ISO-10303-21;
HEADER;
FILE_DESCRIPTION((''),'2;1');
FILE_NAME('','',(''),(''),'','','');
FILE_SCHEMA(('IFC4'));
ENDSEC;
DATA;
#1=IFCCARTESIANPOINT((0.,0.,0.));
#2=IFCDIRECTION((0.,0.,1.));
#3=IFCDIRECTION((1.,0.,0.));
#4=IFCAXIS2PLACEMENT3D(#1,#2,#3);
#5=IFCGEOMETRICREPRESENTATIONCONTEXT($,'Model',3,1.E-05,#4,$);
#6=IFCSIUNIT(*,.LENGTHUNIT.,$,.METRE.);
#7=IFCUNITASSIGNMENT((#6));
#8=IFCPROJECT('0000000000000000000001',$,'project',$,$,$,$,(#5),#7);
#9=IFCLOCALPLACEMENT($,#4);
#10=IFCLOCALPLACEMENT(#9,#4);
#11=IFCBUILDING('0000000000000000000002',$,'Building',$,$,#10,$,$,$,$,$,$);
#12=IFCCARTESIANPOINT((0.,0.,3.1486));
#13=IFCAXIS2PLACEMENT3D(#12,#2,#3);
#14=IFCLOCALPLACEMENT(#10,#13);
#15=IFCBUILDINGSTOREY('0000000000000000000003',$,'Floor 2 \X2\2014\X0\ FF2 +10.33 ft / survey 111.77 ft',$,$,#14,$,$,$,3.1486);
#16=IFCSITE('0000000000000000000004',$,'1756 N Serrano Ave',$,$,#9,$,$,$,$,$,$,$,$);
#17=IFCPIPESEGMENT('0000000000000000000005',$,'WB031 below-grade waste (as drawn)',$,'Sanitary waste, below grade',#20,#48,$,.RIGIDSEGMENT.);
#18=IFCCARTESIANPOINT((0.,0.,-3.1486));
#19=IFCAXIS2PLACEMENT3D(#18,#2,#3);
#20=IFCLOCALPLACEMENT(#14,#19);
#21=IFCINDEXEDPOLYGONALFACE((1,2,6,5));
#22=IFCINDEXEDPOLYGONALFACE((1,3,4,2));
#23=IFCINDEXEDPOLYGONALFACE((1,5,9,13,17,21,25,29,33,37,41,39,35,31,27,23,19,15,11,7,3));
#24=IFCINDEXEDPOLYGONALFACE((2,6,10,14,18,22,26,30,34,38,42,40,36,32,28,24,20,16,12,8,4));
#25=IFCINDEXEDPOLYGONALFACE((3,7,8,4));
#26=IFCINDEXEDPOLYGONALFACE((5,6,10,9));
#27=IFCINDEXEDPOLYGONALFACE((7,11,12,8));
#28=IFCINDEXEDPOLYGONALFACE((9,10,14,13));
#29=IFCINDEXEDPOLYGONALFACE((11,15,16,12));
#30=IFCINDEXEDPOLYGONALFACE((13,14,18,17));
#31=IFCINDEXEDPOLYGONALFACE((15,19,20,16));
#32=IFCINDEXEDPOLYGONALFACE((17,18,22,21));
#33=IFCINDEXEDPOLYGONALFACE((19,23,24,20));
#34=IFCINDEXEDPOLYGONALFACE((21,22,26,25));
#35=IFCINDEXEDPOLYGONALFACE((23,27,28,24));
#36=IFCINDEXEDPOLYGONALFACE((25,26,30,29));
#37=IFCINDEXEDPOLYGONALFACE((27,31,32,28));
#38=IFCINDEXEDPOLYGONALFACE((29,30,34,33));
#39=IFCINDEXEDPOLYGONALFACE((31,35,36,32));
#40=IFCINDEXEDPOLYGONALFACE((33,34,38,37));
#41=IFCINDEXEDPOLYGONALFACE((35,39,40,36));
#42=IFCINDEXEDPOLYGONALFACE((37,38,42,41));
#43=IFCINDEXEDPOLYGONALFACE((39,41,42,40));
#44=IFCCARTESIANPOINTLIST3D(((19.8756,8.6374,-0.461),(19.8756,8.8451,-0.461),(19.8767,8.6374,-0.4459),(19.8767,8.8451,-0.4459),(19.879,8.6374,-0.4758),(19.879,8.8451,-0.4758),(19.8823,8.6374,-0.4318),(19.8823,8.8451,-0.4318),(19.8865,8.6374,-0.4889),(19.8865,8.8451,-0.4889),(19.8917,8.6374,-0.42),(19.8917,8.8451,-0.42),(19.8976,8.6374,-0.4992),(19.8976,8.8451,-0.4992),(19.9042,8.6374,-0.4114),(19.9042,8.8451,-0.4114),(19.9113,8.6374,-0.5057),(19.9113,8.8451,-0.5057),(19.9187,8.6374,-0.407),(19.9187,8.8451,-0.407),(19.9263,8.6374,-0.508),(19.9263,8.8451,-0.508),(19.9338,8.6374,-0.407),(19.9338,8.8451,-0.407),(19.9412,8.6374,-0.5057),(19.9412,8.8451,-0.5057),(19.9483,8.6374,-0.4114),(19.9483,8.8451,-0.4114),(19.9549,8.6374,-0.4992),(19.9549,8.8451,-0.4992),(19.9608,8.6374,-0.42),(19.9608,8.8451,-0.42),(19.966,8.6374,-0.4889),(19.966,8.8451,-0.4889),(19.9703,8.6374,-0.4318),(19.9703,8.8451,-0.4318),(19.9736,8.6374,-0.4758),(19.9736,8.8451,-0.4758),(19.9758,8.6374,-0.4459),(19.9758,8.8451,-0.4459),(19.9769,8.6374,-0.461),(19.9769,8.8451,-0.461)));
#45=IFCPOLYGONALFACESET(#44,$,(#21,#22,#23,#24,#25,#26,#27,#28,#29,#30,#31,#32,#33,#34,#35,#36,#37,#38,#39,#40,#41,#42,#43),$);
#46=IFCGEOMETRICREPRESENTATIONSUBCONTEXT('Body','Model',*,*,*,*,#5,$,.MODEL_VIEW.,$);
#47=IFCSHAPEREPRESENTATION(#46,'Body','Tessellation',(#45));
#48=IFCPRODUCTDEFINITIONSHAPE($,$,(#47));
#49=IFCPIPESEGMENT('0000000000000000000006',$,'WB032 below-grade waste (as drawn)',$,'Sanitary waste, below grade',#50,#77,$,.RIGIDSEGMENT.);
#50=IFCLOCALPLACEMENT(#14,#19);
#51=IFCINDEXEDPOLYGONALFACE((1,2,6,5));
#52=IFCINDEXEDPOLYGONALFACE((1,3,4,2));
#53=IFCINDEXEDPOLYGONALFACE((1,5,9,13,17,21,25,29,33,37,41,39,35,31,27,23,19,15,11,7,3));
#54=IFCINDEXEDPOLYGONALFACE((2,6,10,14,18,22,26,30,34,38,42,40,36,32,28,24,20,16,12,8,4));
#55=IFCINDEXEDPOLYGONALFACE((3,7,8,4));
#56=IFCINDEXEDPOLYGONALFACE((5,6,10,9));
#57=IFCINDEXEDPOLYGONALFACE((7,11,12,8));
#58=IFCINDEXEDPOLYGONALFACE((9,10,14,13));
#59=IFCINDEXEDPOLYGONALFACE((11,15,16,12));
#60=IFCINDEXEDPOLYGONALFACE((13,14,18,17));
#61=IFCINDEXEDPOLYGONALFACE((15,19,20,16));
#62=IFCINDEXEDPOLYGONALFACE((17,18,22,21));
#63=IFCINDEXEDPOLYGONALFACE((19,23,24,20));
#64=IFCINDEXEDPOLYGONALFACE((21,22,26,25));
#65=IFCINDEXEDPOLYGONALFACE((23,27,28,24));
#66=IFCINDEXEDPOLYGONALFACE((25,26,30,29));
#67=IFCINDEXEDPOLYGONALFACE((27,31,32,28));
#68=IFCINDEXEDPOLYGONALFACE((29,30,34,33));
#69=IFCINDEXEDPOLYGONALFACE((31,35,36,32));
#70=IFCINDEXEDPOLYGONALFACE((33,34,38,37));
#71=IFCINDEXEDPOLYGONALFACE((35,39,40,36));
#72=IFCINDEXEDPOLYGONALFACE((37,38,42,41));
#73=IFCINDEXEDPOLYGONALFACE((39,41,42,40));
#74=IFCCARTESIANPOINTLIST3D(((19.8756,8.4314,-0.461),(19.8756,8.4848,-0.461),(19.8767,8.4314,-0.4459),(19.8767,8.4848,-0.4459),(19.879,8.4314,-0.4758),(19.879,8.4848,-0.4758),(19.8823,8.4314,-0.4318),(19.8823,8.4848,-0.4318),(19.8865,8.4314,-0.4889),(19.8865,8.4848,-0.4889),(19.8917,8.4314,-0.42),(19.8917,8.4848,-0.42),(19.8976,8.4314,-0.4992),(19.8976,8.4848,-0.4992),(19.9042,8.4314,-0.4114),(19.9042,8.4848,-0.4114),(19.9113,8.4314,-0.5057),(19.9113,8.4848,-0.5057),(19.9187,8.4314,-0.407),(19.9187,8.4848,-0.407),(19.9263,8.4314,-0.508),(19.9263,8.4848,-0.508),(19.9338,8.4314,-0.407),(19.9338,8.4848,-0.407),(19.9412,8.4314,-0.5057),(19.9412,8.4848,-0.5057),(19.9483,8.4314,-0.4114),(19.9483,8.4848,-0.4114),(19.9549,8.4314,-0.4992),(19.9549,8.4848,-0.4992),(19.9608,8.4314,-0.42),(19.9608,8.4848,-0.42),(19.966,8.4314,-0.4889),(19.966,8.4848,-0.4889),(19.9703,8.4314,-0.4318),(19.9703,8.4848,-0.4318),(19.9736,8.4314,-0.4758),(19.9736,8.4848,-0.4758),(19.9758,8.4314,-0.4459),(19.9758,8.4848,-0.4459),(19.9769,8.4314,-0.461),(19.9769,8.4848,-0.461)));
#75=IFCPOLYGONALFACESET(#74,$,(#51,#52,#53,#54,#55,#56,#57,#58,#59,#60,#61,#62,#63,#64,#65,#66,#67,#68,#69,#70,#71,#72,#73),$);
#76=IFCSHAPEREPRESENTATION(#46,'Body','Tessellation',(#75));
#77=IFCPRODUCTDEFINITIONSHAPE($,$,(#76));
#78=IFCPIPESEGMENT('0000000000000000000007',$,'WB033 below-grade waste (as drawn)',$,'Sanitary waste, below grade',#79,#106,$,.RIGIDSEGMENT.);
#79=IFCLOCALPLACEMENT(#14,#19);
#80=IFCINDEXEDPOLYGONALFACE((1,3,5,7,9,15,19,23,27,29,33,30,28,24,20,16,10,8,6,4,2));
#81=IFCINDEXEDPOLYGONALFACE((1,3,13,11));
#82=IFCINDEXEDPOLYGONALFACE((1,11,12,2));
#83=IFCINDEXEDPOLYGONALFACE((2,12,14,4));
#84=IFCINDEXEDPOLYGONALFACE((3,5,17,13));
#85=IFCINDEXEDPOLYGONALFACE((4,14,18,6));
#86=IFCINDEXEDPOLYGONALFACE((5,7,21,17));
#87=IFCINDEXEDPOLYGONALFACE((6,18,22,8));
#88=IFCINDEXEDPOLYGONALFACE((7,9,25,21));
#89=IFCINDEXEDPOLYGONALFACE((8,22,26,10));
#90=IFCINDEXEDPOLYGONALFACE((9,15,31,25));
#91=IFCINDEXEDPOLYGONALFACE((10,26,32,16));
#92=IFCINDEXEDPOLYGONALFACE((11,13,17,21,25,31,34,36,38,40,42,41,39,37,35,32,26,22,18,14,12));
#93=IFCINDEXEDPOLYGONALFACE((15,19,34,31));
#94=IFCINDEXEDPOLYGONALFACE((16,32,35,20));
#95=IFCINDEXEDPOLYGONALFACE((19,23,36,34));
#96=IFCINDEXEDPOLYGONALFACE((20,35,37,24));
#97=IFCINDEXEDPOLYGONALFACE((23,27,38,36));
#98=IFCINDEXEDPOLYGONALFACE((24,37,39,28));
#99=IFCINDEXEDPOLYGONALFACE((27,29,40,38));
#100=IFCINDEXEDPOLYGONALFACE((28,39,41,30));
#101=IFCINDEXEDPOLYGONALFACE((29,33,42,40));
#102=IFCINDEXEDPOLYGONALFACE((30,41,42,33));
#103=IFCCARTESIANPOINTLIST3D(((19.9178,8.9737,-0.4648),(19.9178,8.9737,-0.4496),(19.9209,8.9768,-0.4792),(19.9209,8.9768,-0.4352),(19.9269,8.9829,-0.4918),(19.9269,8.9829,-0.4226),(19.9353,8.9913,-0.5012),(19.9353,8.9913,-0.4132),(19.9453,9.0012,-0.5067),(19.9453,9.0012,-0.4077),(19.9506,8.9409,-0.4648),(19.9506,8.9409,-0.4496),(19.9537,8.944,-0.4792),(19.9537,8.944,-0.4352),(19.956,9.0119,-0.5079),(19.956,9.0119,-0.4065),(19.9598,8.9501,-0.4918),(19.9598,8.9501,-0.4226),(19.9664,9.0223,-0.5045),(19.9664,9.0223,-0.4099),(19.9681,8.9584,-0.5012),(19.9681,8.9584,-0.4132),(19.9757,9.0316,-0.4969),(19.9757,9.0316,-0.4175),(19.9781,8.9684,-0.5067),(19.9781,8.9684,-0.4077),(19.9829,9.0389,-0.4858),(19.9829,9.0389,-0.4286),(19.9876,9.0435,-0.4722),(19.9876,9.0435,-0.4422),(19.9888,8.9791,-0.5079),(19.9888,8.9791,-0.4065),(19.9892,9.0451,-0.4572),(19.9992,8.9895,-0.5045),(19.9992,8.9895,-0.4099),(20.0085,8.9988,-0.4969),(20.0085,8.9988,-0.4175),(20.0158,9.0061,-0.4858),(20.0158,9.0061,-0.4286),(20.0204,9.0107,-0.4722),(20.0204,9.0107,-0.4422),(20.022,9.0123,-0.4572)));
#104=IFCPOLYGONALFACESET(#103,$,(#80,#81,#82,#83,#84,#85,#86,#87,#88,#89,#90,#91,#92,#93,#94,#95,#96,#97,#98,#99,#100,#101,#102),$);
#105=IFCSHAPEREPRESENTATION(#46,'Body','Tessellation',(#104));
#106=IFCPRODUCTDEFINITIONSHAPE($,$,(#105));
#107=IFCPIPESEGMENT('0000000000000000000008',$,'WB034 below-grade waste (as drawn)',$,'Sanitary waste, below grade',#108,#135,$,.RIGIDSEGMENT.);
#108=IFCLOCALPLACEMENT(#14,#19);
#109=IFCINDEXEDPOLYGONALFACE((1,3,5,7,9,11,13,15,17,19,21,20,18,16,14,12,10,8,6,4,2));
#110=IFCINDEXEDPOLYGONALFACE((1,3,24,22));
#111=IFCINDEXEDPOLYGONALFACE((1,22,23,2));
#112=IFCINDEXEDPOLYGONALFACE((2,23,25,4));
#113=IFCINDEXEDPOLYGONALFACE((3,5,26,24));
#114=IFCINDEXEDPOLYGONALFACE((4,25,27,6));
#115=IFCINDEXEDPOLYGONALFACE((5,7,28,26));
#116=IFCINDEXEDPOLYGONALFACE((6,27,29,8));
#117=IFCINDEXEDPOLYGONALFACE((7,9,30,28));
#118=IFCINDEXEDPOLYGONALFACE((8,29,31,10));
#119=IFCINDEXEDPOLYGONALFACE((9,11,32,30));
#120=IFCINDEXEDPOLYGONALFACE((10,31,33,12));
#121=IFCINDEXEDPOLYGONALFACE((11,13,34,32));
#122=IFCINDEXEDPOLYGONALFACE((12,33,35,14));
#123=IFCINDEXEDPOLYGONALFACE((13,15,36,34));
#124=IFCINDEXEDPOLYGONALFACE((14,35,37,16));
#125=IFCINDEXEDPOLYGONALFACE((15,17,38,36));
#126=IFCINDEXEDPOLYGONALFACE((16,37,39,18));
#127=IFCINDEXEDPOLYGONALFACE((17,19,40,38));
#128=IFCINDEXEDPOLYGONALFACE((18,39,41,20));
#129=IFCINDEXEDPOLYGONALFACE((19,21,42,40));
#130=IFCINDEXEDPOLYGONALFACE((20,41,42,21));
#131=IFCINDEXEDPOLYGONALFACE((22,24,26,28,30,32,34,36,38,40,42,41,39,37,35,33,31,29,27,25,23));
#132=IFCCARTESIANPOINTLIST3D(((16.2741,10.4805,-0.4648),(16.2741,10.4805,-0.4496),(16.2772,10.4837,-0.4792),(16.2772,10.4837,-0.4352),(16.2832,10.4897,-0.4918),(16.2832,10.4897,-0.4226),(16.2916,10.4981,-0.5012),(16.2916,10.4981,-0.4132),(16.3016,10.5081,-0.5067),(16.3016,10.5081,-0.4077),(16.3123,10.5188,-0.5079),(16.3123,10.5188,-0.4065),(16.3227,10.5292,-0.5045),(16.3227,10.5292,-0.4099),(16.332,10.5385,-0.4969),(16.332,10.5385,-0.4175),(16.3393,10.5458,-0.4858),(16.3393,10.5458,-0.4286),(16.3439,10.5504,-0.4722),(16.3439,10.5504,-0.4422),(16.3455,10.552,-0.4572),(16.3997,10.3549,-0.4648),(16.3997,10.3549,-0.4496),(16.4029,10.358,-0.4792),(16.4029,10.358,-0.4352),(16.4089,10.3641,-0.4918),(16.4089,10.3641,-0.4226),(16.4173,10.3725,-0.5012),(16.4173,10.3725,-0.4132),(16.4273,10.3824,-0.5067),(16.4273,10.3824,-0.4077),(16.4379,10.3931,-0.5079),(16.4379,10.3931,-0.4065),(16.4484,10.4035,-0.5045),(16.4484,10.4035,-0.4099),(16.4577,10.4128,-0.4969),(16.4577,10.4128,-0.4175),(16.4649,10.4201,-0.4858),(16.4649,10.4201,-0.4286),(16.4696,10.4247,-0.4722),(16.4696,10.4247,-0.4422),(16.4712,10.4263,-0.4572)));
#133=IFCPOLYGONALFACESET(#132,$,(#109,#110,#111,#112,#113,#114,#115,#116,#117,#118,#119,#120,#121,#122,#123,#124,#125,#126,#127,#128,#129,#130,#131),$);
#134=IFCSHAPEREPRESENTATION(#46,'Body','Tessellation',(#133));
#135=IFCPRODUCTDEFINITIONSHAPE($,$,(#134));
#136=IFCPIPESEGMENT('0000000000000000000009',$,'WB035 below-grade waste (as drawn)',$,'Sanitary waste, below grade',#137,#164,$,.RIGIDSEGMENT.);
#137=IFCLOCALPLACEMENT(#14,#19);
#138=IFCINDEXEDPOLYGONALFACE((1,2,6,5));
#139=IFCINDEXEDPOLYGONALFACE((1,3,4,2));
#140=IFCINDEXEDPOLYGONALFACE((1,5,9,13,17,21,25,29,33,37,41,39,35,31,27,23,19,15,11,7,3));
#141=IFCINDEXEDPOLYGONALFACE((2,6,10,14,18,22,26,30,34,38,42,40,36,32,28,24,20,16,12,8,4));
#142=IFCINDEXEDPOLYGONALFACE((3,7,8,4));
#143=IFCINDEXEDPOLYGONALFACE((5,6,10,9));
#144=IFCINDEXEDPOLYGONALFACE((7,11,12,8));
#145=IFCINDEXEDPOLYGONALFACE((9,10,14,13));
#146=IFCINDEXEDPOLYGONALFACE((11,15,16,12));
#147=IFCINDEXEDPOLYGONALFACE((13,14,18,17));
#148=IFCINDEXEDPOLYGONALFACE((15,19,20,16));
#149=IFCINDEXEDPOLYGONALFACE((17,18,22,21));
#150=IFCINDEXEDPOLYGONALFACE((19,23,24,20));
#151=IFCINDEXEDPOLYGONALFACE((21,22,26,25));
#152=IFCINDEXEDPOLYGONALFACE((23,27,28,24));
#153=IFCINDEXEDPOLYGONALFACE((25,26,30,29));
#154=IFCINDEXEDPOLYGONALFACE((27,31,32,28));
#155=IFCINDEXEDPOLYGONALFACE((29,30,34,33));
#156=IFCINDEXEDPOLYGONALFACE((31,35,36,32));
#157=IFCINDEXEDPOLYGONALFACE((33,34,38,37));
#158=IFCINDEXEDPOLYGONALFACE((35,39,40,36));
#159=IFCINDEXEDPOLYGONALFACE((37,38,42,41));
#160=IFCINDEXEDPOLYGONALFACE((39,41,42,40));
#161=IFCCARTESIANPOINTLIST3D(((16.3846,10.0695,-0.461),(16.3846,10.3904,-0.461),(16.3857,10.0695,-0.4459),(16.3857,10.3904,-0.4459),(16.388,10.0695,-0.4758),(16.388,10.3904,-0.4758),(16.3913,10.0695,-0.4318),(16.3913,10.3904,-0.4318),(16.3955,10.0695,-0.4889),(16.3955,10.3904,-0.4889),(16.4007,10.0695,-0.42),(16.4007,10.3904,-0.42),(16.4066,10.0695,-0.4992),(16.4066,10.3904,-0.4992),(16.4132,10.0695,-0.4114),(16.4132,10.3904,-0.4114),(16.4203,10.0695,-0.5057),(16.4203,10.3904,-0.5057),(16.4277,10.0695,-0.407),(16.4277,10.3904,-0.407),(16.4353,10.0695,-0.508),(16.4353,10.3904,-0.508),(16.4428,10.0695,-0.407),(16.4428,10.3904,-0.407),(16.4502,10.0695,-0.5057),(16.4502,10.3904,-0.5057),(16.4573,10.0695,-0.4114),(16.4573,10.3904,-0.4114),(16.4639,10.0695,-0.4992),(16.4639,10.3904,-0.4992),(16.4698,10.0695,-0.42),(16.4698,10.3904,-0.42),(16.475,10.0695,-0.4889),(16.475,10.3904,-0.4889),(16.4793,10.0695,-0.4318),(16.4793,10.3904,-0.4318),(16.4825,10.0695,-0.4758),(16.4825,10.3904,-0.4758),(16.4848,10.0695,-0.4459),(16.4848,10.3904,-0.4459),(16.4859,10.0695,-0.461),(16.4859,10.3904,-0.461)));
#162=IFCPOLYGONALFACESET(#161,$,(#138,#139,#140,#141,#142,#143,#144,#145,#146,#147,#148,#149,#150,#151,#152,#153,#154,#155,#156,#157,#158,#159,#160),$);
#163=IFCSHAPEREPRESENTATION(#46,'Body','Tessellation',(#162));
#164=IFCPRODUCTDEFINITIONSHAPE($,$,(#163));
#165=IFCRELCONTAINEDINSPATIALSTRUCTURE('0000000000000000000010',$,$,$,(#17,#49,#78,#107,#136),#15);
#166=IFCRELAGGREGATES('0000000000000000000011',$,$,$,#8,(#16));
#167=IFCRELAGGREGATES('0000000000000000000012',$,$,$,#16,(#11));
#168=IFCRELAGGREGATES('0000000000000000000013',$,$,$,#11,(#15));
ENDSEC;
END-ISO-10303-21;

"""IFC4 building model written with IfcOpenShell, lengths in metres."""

from ifc_helpers import new_model, entity, si_unit, frame, origin_with_axes, place, context, subcontext, project, spatial, element, save


model = new_model("IFC4")

# Units and contexts
model_context = context("Model", 3, precision=1e-05, world=origin_with_axes())
body_context = subcontext(model_context, "Body", "Model", "MODEL_VIEW")
ifc_project = project(units=[si_unit("LENGTHUNIT", "METRE")], contexts=[model_context])

# Site, building, storey
site_placement = place(None, origin_with_axes())
site = spatial("IfcSite", under=ifc_project, at=site_placement, Name="1756 N Serrano Ave")
building_placement = place(site_placement, origin_with_axes())
building = spatial("IfcBuilding", under=site, at=building_placement, Name="Building")
storey_placement = place(building_placement, frame((0.0, 0.0, 3.1486), z_axis=(0.0, 0.0, 1.0), x_axis=(1.0, 0.0, 0.0)))
storey = spatial("IfcBuildingStorey", under=building, at=storey_placement, Name="Floor 2 — FF2 +10.33 ft / survey 111.77 ft", Elevation=3.1486)

# Pipe segments
pipe_segment_1_placement = place(storey_placement, frame((0.0, 0.0, -3.1486), z_axis=(0.0, 0.0, 1.0), x_axis=(1.0, 0.0, 0.0)))
element("IfcPipeSegment", 1, at=pipe_segment_1_placement, inside=storey, Name="WB031 below-grade waste (as drawn)", ObjectType="Sanitary waste, below grade", PredefinedType="RIGIDSEGMENT", context=body_context, shape_type="AdvancedSweptSolid", body=[
    entity("IfcSweptDiskSolid", entity("IfcPolyline", [entity("IfcCartesianPoint", [19.9263, 8.8451, -0.4572]), entity("IfcCartesianPoint", [19.9263, 8.6374, -0.4572])]), 0.0508),
])
pipe_segment_2_placement = place(storey_placement, frame((0.0, 0.0, -3.1486), z_axis=(0.0, 0.0, 1.0), x_axis=(1.0, 0.0, 0.0)))
element("IfcPipeSegment", 2, at=pipe_segment_2_placement, inside=storey, Name="WB032 below-grade waste (as drawn)", ObjectType="Sanitary waste, below grade", PredefinedType="RIGIDSEGMENT", context=body_context, shape_type="AdvancedSweptSolid", body=[
    entity("IfcSweptDiskSolid", entity("IfcPolyline", [entity("IfcCartesianPoint", [19.9263, 8.4848, -0.4572]), entity("IfcCartesianPoint", [19.9263, 8.4314, -0.4572])]), 0.0508),
])
pipe_segment_3_placement = place(storey_placement, frame((0.0, 0.0, -3.1486), z_axis=(0.0, 0.0, 1.0), x_axis=(1.0, 0.0, 0.0)))
element("IfcPipeSegment", 3, at=pipe_segment_3_placement, inside=storey, Name="WB033 below-grade waste (as drawn)", ObjectType="Sanitary waste, below grade", PredefinedType="RIGIDSEGMENT", context=body_context, shape_type="AdvancedSweptSolid", body=[
    entity("IfcSweptDiskSolid", entity("IfcPolyline", [entity("IfcCartesianPoint", [19.9533, 9.0092, -0.4572]), entity("IfcCartesianPoint", [19.9861, 8.9764, -0.4572])]), 0.0508),
])
pipe_segment_4_placement = place(storey_placement, frame((0.0, 0.0, -3.1486), z_axis=(0.0, 0.0, 1.0), x_axis=(1.0, 0.0, 0.0)))
element("IfcPipeSegment", 4, at=pipe_segment_4_placement, inside=storey, Name="WB034 below-grade waste (as drawn)", ObjectType="Sanitary waste, below grade", PredefinedType="RIGIDSEGMENT", context=body_context, shape_type="AdvancedSweptSolid", body=[
    entity("IfcSweptDiskSolid", entity("IfcPolyline", [entity("IfcCartesianPoint", [16.3096, 10.5161, -0.4572]), entity("IfcCartesianPoint", [16.4353, 10.3904, -0.4572])]), 0.0508),
])
pipe_segment_5_placement = place(storey_placement, frame((0.0, 0.0, -3.1486), z_axis=(0.0, 0.0, 1.0), x_axis=(1.0, 0.0, 0.0)))
element("IfcPipeSegment", 5, at=pipe_segment_5_placement, inside=storey, Name="WB035 below-grade waste (as drawn)", ObjectType="Sanitary waste, below grade", PredefinedType="RIGIDSEGMENT", context=body_context, shape_type="AdvancedSweptSolid", body=[
    entity("IfcSweptDiskSolid", entity("IfcPolyline", [entity("IfcCartesianPoint", [16.4353, 10.3904, -0.4572]), entity("IfcCartesianPoint", [16.4353, 10.0695, -0.4572])]), 0.0508),
])

save(model, "model.ifc")
